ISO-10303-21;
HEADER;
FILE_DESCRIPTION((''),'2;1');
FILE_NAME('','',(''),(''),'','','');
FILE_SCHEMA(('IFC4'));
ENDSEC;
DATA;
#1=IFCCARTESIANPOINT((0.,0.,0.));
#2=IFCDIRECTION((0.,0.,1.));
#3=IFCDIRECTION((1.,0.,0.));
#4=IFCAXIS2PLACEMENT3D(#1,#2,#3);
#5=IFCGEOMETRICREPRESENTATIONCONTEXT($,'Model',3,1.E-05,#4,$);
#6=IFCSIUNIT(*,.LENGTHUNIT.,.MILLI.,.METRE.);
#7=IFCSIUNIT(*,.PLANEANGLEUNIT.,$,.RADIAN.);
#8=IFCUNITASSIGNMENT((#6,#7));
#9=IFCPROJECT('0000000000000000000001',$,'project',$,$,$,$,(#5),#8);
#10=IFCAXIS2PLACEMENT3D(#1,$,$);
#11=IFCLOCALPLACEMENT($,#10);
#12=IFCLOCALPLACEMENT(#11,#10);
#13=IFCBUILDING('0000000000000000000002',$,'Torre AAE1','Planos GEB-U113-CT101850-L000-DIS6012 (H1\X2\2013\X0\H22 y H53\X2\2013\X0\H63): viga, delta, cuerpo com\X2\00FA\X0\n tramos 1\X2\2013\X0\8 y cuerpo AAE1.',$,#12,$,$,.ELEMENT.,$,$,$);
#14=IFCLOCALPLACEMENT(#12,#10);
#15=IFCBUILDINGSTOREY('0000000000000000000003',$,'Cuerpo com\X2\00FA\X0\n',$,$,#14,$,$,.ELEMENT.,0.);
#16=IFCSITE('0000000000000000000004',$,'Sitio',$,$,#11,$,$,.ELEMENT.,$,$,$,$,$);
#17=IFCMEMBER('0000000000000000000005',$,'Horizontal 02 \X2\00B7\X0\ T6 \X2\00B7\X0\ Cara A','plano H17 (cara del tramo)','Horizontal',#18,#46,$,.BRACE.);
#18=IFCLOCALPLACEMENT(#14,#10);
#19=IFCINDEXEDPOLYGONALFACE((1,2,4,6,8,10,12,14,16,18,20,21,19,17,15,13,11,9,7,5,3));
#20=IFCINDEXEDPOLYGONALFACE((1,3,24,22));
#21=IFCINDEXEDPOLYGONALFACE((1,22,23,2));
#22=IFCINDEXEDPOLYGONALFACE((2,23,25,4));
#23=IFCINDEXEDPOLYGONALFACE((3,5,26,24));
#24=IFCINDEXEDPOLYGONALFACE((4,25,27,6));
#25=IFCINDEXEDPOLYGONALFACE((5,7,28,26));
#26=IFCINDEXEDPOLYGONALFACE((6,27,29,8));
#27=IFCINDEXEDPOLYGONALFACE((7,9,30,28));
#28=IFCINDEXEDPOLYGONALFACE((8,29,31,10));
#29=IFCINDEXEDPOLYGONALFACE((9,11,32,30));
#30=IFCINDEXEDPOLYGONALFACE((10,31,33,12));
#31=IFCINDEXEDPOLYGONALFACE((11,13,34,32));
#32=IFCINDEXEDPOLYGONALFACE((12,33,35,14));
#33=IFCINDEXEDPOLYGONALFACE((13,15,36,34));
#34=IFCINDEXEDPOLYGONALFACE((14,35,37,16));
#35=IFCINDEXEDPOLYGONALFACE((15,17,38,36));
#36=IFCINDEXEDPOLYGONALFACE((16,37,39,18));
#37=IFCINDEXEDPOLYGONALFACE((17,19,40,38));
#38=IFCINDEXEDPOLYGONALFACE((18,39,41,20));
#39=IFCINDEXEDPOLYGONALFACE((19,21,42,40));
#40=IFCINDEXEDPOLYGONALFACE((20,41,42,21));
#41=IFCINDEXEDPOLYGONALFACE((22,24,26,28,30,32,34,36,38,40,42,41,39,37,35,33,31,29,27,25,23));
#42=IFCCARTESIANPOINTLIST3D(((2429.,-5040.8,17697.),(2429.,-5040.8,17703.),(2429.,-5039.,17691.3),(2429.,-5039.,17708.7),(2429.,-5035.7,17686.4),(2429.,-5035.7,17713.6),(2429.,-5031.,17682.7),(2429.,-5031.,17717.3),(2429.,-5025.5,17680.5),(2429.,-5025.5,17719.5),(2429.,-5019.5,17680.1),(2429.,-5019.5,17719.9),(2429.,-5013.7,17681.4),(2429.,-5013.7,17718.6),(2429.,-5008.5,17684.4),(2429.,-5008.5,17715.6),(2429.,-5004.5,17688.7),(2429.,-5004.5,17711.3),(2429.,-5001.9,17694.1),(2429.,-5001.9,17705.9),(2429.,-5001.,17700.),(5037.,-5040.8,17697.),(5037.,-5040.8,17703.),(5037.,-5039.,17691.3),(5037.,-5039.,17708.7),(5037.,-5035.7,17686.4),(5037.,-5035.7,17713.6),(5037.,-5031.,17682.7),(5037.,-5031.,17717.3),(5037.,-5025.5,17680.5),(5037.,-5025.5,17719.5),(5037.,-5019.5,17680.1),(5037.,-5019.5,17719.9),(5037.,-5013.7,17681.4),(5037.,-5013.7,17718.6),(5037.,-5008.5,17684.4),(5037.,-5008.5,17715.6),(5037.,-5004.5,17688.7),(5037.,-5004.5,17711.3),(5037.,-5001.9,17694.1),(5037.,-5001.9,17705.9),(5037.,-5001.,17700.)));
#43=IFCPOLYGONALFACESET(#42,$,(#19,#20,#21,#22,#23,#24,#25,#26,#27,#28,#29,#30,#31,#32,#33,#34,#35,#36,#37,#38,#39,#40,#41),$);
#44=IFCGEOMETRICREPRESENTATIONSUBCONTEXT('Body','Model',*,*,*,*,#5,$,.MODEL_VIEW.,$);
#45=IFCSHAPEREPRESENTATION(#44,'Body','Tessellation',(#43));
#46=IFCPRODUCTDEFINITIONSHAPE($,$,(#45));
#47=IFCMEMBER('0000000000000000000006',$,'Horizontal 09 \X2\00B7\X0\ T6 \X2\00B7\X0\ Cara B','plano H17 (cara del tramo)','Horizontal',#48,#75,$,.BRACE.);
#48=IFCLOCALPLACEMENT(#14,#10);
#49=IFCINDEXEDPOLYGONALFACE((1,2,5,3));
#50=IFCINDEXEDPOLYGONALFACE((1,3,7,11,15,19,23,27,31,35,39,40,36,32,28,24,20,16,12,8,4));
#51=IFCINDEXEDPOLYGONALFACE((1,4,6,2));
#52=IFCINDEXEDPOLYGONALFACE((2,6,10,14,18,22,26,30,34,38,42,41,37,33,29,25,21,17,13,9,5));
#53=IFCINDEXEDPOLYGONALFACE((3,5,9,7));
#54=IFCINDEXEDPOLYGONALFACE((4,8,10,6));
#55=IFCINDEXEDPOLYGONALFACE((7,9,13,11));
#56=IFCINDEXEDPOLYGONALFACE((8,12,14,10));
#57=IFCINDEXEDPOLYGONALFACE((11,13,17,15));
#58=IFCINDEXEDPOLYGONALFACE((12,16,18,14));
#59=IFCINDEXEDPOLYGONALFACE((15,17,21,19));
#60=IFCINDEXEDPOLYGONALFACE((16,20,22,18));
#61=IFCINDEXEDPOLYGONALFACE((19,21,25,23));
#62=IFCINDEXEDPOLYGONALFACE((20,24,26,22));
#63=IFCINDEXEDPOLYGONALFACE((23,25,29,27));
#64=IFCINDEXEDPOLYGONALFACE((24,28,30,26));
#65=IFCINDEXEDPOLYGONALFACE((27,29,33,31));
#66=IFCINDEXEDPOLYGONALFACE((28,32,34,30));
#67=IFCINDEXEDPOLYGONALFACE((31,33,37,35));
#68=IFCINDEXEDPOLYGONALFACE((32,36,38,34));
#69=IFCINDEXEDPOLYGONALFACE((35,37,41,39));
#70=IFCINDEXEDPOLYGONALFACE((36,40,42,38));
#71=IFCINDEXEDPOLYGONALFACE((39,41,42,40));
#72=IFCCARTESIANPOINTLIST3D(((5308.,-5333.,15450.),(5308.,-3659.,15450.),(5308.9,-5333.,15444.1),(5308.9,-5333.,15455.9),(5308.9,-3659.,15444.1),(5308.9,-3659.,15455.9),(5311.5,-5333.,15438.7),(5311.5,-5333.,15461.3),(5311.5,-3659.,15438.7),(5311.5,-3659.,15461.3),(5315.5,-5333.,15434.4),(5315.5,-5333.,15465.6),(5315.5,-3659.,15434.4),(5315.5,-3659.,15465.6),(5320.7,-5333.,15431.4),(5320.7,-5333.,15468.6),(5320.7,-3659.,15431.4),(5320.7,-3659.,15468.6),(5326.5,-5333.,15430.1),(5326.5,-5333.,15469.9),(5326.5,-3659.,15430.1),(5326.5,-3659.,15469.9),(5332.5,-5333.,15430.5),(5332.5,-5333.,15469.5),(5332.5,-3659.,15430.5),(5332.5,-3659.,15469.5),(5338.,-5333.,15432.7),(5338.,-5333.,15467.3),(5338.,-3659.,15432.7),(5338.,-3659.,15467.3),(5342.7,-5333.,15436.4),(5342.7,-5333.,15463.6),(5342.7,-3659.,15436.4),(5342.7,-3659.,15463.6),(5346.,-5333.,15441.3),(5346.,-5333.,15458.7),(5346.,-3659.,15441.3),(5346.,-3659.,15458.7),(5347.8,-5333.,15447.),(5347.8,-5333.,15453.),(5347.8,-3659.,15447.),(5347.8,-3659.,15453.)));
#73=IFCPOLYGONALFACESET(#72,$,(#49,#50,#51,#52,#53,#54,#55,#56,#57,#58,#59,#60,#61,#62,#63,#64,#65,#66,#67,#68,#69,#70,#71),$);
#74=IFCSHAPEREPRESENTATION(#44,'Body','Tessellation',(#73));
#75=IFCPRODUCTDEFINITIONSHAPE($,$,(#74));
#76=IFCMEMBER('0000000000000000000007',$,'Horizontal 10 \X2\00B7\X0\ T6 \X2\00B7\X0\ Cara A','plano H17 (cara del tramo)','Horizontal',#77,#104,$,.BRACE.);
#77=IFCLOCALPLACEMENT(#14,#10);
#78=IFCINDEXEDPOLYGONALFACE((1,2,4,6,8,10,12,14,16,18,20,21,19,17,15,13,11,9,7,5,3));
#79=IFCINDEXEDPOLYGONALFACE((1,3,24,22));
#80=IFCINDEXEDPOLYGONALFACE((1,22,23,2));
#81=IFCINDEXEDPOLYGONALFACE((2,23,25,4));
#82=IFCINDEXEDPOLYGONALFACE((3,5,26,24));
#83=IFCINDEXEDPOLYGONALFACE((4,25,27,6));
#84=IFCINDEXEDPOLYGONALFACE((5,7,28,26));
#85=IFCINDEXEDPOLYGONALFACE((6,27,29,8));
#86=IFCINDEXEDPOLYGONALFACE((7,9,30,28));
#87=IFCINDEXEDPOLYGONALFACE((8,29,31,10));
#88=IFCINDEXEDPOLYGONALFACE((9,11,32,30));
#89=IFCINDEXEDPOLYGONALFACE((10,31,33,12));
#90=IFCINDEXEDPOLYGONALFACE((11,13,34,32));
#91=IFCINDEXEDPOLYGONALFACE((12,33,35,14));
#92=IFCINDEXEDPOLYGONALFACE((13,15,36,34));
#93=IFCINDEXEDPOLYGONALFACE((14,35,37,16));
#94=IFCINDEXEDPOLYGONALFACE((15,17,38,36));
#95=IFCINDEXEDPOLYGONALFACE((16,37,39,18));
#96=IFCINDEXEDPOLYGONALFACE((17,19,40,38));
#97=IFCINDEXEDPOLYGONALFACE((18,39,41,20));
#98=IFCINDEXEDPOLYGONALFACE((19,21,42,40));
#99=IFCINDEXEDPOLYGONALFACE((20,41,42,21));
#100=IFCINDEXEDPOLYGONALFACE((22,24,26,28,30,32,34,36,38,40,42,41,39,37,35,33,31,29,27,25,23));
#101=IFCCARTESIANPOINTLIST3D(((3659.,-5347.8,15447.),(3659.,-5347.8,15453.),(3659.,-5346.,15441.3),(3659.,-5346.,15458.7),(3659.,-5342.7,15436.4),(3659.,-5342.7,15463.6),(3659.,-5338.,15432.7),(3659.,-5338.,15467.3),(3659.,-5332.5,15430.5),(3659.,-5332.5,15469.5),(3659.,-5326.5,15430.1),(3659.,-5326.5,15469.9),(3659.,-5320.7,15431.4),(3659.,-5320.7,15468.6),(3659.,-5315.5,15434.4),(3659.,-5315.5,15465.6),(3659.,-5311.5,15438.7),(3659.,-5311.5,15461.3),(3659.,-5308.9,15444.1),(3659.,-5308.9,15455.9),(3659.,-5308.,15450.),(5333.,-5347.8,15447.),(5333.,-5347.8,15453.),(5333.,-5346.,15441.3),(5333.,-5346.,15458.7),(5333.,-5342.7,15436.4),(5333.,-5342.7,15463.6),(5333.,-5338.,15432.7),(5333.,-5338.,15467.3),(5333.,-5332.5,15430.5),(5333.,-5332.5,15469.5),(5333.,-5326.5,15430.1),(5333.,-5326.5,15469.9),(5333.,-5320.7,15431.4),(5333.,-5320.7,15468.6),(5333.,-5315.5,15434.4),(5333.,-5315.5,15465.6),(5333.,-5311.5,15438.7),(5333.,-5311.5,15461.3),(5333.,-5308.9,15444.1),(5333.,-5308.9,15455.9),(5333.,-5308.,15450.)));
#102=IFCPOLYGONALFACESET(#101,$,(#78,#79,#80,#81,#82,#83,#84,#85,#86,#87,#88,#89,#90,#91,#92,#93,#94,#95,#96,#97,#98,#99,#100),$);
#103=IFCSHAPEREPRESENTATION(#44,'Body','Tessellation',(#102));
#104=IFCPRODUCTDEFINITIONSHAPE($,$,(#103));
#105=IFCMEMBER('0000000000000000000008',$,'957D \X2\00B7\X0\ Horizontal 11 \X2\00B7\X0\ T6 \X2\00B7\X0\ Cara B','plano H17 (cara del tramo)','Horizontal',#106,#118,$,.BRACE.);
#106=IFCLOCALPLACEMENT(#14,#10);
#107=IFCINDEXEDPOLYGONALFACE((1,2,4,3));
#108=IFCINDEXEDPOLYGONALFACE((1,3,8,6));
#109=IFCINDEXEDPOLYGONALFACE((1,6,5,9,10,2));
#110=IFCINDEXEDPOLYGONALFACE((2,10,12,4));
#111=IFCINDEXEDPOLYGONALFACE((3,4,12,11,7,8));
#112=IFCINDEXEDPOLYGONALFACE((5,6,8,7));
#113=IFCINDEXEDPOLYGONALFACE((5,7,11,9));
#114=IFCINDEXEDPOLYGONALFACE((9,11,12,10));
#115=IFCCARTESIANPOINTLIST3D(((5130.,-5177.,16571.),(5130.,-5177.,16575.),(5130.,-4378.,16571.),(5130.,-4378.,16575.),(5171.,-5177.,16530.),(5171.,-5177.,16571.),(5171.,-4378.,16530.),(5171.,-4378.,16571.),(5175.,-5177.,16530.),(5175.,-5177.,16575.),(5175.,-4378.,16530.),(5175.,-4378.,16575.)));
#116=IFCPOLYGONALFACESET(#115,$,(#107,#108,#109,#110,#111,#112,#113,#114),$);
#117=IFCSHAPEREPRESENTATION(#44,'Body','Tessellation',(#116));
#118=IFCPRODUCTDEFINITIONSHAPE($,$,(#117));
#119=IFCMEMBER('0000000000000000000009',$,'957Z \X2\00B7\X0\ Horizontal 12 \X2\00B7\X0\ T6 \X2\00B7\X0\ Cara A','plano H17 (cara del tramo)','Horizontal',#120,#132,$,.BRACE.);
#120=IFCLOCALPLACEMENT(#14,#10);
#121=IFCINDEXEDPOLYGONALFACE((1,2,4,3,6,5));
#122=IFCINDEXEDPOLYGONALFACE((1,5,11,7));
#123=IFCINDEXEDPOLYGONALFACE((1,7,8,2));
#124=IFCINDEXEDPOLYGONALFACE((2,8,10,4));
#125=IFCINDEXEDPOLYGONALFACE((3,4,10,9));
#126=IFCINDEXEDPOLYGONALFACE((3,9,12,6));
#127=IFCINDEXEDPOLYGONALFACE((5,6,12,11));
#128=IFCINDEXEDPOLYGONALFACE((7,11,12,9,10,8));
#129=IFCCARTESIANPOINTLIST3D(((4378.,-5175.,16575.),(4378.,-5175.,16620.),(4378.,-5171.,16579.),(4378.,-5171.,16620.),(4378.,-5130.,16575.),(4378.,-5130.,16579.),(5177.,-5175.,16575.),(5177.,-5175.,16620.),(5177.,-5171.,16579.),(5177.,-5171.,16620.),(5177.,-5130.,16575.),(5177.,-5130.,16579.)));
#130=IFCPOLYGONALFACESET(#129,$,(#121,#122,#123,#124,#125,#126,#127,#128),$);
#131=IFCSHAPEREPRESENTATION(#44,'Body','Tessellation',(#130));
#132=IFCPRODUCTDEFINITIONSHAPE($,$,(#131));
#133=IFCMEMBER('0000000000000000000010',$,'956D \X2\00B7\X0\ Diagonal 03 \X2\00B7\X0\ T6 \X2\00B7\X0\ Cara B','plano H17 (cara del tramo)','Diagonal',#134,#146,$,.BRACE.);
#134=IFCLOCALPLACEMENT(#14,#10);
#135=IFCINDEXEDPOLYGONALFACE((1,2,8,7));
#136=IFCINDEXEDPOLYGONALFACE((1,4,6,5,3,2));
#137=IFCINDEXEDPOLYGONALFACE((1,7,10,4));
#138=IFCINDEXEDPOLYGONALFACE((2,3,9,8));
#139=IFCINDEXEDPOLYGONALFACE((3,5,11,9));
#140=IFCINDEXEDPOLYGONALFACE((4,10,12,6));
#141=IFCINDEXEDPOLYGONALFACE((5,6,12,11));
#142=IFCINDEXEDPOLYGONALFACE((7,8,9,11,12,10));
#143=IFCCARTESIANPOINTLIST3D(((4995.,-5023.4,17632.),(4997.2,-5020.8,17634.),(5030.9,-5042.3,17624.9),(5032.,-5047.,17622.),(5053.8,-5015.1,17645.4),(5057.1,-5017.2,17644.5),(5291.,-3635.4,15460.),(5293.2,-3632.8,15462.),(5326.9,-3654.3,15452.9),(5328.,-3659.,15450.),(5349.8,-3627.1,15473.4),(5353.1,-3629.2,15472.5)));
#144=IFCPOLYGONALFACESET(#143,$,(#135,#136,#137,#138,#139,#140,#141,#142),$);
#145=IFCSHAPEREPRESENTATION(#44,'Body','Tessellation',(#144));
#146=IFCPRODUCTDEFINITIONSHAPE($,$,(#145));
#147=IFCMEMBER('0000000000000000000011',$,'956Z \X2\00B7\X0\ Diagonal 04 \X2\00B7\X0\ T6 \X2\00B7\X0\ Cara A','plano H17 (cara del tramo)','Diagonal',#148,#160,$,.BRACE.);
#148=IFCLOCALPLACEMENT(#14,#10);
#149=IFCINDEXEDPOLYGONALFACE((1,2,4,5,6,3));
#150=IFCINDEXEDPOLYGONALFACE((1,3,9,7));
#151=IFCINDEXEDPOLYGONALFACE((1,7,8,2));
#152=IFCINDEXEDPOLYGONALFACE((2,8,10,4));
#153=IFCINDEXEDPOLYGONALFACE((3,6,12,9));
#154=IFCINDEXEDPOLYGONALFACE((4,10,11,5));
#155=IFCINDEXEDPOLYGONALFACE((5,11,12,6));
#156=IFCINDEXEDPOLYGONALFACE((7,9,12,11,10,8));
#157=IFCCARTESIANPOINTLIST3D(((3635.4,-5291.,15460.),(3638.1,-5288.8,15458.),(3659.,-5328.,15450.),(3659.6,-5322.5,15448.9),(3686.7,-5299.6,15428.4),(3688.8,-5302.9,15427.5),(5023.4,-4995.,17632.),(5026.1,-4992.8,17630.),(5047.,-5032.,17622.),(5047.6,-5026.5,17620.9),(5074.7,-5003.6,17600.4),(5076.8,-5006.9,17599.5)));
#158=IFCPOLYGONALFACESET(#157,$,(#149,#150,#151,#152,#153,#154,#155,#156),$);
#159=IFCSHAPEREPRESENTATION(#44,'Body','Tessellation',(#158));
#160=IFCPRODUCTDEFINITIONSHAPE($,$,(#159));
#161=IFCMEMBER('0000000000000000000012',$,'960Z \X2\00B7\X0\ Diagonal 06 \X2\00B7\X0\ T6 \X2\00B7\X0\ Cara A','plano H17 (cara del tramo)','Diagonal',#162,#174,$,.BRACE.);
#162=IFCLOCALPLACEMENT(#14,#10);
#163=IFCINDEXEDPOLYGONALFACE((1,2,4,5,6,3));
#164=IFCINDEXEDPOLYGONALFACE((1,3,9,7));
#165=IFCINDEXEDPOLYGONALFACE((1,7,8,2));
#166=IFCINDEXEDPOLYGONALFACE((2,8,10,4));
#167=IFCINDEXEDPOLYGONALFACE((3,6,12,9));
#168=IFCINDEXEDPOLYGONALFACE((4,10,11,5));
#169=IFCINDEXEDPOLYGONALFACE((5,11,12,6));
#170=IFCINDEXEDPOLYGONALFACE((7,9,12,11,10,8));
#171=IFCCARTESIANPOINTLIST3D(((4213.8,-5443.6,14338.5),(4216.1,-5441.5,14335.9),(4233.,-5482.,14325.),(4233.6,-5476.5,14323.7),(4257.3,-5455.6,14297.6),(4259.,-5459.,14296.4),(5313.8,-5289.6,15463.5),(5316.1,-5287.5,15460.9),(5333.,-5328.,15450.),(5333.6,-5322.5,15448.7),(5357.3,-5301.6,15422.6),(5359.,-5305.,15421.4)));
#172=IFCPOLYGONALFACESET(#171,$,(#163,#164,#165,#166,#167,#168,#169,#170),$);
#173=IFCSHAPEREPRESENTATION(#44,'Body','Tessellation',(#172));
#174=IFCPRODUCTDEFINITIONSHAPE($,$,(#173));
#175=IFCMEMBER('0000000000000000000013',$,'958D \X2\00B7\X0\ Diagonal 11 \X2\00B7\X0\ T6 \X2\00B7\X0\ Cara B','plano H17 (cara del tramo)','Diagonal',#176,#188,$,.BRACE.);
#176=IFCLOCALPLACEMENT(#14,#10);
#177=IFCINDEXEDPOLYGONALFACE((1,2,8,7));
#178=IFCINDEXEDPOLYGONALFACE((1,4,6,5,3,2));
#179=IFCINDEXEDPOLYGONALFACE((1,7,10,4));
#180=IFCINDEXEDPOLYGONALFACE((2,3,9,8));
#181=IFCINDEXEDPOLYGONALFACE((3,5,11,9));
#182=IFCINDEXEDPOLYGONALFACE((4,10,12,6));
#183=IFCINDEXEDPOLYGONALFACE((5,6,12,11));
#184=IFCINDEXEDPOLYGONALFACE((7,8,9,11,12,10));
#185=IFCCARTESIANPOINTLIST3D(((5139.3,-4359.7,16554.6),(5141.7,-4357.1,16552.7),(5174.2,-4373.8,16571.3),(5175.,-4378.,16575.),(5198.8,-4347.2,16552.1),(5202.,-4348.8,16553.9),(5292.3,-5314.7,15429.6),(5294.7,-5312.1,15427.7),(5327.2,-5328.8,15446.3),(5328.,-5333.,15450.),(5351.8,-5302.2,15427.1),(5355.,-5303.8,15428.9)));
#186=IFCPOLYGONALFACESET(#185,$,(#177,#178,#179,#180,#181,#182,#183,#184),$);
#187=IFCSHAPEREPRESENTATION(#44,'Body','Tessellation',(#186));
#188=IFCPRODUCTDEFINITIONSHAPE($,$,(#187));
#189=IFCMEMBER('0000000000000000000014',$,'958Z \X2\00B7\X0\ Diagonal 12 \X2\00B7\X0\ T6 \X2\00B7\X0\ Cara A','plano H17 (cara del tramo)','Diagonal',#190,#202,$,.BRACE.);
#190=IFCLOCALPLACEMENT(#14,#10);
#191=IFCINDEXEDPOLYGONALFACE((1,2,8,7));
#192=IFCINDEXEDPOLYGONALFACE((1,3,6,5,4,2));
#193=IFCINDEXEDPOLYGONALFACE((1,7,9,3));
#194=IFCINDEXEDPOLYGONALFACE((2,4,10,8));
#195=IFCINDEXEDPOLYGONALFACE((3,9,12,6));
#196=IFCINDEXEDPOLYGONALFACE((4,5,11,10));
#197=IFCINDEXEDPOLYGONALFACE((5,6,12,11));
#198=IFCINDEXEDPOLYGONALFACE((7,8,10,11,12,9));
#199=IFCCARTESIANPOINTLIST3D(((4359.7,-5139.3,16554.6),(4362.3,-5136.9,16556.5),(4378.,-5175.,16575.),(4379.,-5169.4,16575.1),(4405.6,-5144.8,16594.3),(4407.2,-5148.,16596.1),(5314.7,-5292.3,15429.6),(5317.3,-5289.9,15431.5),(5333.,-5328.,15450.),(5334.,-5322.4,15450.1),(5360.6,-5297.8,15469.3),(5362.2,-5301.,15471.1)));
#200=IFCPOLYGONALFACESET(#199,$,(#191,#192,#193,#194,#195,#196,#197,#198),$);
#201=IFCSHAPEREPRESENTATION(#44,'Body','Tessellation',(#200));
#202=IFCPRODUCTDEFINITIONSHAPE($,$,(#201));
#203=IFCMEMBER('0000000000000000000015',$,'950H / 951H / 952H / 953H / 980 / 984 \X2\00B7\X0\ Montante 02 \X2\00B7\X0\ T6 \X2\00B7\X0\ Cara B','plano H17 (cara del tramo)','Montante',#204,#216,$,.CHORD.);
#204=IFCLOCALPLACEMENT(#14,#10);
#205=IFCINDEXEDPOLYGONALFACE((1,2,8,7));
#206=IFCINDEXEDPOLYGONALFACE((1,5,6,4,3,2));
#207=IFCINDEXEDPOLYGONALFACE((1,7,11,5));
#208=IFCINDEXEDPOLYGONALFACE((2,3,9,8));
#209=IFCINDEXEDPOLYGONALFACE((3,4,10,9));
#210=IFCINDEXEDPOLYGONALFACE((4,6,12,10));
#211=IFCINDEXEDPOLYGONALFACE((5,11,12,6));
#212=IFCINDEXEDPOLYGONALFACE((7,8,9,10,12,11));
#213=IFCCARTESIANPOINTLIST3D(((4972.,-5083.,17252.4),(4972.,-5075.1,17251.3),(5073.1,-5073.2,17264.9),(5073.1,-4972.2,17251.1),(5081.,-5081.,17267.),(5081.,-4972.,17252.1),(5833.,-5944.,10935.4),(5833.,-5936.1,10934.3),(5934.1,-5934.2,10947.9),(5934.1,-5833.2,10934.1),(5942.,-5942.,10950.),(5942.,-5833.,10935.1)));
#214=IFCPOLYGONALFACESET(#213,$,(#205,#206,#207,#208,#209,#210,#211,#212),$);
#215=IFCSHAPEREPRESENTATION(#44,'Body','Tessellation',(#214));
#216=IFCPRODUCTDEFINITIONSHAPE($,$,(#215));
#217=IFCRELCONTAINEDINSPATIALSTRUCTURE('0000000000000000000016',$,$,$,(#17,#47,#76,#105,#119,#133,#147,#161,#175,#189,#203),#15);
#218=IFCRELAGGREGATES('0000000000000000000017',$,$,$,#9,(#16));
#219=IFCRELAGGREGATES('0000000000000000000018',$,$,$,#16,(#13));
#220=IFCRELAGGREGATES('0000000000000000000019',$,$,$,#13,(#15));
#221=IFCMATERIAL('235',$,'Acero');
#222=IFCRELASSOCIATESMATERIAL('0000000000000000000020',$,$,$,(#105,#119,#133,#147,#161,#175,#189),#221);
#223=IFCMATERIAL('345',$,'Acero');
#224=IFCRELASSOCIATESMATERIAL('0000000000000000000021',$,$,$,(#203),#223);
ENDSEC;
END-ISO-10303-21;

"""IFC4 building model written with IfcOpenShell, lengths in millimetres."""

from ifc_helpers import new_model, si_unit, frame, frame_2d, origin, origin_with_axes, place, context, subcontext, project, spatial, circle, l_section, extrude, material, element, save


model = new_model("IFC4")

# Units and contexts
model_context = context("Model", 3, precision=1e-05, world=origin_with_axes())
body_context = subcontext(model_context, "Body", "Model", "MODEL_VIEW")
ifc_project = project(units=[si_unit("LENGTHUNIT", "METRE", prefix="MILLI"), si_unit("PLANEANGLEUNIT", "RADIAN")], contexts=[model_context])

# Site, building, storey
site_placement = place(None, origin())
site = spatial("IfcSite", under=ifc_project, at=site_placement, Name="Sitio", CompositionType="ELEMENT")
building_placement = place(site_placement, origin())
building = spatial("IfcBuilding", under=site, at=building_placement, Name="Torre AAE1", Description="Planos GEB-U113-CT101850-L000-DIS6012 (H1–H22 y H53–H63): viga, delta, cuerpo común tramos 1–8 y cuerpo AAE1.", CompositionType="ELEMENT")
storey_placement = place(building_placement, origin())
storey = spatial("IfcBuildingStorey", under=building, at=storey_placement, Name="Cuerpo común", CompositionType="ELEMENT", Elevation=0.0)

# Members
for number, where, z_axis, x_axis, name in (
    (1, (5037.0, -5021.0, 17700.0), (-1.0, 0.0, 0.0), (0.0, 1.0, 0.0), "Horizontal 02 · T6 · Cara A"),
):
    element("IfcMember", number, at=place(storey_placement, frame(where, z_axis=z_axis, x_axis=x_axis)), inside=storey, Name=name, Description="plano H17 (cara del tramo)", ObjectType="Horizontal", PredefinedType="BRACE", context=body_context, shape_type="SweptSolid", body=[
        extrude(circle(Radius=20.0), None, (0.0, 0.0, 1.0), 2608.0),
    ])
for number, where, z_axis, x_axis, name in (
    (2, (5328.0, -3659.0, 15450.0), (0.0, -1.0, 0.0), (-1.0, 0.0, 0.0), "Horizontal 09 · T6 · Cara B"),
    (3, (3659.0, -5328.0, 15450.0), (1.0, 0.0, 0.0), (0.0, 1.0, 0.0), "Horizontal 10 · T6 · Cara A"),
):
    element("IfcMember", number, at=place(storey_placement, frame(where, z_axis=z_axis, x_axis=x_axis)), inside=storey, Name=name, Description="plano H17 (cara del tramo)", ObjectType="Horizontal", PredefinedType="BRACE", context=body_context, shape_type="SweptSolid", body=[
        extrude(circle(Radius=20.0), None, (0.0, 0.0, 1.0), 1674.0),
    ])
ifc_material_1 = material(Name="235", Category="Acero")
for number, where, z_axis, x_axis, name in (
    (4, (5175.0, -4378.0, 16575.0), (0.0, -1.0, 0.0), (-1.0, 0.0, 0.0), "957D · Horizontal 11 · T6 · Cara B"),
    (5, (4378.0, -5175.0, 16575.0), (1.0, 0.0, 0.0), (0.0, 1.0, 0.0), "957Z · Horizontal 12 · T6 · Cara A"),
):
    element("IfcMember", number, at=place(storey_placement, frame(where, z_axis=z_axis, x_axis=x_axis)), inside=storey, material=ifc_material_1, Name=name, Description="plano H17 (cara del tramo)", ObjectType="Horizontal", PredefinedType="BRACE", context=body_context, shape_type="SweptSolid", body=[
        extrude(l_section(Depth=45.0, Width=45.0, Thickness=4.0, at=frame_2d((22.5, 22.5))), None, (0.0, 0.0, 1.0), 799.0),
    ])
for number, where, z_axis, x_axis, name in (
    (6, (5032.0, -5047.0, 17622.0), (0.114085, 0.534965, -0.837136), (-0.822462, 0.523514, 0.222463), "956D · Diagonal 03 · T6 · Cara B"),
    (7, (5047.0, -5032.0, 17622.0), (-0.534965, -0.114085, -0.837136), (-0.523514, 0.822462, 0.222463), "956Z · Diagonal 04 · T6 · Cara A"),
):
    element("IfcMember", number, at=place(storey_placement, frame(where, z_axis=z_axis, x_axis=x_axis)), inside=storey, material=ifc_material_1, Name=name, Description="plano H17 (cara del tramo)", ObjectType="Diagonal", PredefinedType="BRACE", context=body_context, shape_type="SweptSolid", body=[
        extrude(l_section(Depth=45.0, Width=45.0, Thickness=4.0, at=frame_2d((22.5, 22.5))), None, (0.0, 0.0, 1.0), 2594.6),
    ])
member_1_placement = place(storey_placement, frame((5333.0, -5328.0, 15450.0), z_axis=(-0.695793, -0.097411, -0.711606), x_axis=(-0.426031, 0.853622, 0.299712)))
element("IfcMember", 8, at=member_1_placement, inside=storey, material=ifc_material_1, Name="960Z · Diagonal 06 · T6 · Cara A", Description="plano H17 (cara del tramo)", ObjectType="Diagonal", PredefinedType="BRACE", context=body_context, shape_type="SweptSolid", body=[
    extrude(l_section(Depth=45.0, Width=45.0, Thickness=4.0, at=frame_2d((22.5, 22.5))), None, (0.0, 0.0, 1.0), 1580.9),
])
for number, where, z_axis, x_axis, name in (
    (9, (5175.0, -4378.0, 16575.0), (0.103128, -0.643706, -0.758292), (-0.793627, 0.40631, -0.452845), "958D · Diagonal 11 · T6 · Cara B"),
    (10, (4378.0, -5175.0, 16575.0), (0.643706, -0.103128, -0.758292), (-0.40631, 0.793627, -0.452845), "958Z · Diagonal 12 · T6 · Cara A"),
):
    element("IfcMember", number, at=place(storey_placement, frame(where, z_axis=z_axis, x_axis=x_axis)), inside=storey, material=ifc_material_1, Name=name, Description="plano H17 (cara del tramo)", ObjectType="Diagonal", PredefinedType="BRACE", context=body_context, shape_type="SweptSolid", body=[
        extrude(l_section(Depth=45.0, Width=45.0, Thickness=4.0, at=frame_2d((22.5, 22.5))), None, (0.0, 0.0, 1.0), 1483.6),
    ])
ifc_material_2 = material(Name="345", Category="Acero")
member_2_placement = place(storey_placement, frame((5081.0, -5081.0, 17267.0), z_axis=(0.133835, -0.133835, -0.981925), x_axis=(-0.991004, -0.018074, -0.132609)))
element("IfcMember", 11, at=member_2_placement, inside=storey, material=ifc_material_2, Name="950H / 951H / 952H / 953H / 980 / 984 · Montante 02 · T6 · Cara B", Description="plano H17 (cara del tramo)", ObjectType="Montante", PredefinedType="CHORD", context=body_context, shape_type="SweptSolid", body=[
    extrude(l_section(Depth=110.0, Width=110.0, Thickness=8.0, at=frame_2d((55.0, 55.0))), None, (0.0, 0.0, 1.0), 6433.3),
])

save(model, "model.ifc")
